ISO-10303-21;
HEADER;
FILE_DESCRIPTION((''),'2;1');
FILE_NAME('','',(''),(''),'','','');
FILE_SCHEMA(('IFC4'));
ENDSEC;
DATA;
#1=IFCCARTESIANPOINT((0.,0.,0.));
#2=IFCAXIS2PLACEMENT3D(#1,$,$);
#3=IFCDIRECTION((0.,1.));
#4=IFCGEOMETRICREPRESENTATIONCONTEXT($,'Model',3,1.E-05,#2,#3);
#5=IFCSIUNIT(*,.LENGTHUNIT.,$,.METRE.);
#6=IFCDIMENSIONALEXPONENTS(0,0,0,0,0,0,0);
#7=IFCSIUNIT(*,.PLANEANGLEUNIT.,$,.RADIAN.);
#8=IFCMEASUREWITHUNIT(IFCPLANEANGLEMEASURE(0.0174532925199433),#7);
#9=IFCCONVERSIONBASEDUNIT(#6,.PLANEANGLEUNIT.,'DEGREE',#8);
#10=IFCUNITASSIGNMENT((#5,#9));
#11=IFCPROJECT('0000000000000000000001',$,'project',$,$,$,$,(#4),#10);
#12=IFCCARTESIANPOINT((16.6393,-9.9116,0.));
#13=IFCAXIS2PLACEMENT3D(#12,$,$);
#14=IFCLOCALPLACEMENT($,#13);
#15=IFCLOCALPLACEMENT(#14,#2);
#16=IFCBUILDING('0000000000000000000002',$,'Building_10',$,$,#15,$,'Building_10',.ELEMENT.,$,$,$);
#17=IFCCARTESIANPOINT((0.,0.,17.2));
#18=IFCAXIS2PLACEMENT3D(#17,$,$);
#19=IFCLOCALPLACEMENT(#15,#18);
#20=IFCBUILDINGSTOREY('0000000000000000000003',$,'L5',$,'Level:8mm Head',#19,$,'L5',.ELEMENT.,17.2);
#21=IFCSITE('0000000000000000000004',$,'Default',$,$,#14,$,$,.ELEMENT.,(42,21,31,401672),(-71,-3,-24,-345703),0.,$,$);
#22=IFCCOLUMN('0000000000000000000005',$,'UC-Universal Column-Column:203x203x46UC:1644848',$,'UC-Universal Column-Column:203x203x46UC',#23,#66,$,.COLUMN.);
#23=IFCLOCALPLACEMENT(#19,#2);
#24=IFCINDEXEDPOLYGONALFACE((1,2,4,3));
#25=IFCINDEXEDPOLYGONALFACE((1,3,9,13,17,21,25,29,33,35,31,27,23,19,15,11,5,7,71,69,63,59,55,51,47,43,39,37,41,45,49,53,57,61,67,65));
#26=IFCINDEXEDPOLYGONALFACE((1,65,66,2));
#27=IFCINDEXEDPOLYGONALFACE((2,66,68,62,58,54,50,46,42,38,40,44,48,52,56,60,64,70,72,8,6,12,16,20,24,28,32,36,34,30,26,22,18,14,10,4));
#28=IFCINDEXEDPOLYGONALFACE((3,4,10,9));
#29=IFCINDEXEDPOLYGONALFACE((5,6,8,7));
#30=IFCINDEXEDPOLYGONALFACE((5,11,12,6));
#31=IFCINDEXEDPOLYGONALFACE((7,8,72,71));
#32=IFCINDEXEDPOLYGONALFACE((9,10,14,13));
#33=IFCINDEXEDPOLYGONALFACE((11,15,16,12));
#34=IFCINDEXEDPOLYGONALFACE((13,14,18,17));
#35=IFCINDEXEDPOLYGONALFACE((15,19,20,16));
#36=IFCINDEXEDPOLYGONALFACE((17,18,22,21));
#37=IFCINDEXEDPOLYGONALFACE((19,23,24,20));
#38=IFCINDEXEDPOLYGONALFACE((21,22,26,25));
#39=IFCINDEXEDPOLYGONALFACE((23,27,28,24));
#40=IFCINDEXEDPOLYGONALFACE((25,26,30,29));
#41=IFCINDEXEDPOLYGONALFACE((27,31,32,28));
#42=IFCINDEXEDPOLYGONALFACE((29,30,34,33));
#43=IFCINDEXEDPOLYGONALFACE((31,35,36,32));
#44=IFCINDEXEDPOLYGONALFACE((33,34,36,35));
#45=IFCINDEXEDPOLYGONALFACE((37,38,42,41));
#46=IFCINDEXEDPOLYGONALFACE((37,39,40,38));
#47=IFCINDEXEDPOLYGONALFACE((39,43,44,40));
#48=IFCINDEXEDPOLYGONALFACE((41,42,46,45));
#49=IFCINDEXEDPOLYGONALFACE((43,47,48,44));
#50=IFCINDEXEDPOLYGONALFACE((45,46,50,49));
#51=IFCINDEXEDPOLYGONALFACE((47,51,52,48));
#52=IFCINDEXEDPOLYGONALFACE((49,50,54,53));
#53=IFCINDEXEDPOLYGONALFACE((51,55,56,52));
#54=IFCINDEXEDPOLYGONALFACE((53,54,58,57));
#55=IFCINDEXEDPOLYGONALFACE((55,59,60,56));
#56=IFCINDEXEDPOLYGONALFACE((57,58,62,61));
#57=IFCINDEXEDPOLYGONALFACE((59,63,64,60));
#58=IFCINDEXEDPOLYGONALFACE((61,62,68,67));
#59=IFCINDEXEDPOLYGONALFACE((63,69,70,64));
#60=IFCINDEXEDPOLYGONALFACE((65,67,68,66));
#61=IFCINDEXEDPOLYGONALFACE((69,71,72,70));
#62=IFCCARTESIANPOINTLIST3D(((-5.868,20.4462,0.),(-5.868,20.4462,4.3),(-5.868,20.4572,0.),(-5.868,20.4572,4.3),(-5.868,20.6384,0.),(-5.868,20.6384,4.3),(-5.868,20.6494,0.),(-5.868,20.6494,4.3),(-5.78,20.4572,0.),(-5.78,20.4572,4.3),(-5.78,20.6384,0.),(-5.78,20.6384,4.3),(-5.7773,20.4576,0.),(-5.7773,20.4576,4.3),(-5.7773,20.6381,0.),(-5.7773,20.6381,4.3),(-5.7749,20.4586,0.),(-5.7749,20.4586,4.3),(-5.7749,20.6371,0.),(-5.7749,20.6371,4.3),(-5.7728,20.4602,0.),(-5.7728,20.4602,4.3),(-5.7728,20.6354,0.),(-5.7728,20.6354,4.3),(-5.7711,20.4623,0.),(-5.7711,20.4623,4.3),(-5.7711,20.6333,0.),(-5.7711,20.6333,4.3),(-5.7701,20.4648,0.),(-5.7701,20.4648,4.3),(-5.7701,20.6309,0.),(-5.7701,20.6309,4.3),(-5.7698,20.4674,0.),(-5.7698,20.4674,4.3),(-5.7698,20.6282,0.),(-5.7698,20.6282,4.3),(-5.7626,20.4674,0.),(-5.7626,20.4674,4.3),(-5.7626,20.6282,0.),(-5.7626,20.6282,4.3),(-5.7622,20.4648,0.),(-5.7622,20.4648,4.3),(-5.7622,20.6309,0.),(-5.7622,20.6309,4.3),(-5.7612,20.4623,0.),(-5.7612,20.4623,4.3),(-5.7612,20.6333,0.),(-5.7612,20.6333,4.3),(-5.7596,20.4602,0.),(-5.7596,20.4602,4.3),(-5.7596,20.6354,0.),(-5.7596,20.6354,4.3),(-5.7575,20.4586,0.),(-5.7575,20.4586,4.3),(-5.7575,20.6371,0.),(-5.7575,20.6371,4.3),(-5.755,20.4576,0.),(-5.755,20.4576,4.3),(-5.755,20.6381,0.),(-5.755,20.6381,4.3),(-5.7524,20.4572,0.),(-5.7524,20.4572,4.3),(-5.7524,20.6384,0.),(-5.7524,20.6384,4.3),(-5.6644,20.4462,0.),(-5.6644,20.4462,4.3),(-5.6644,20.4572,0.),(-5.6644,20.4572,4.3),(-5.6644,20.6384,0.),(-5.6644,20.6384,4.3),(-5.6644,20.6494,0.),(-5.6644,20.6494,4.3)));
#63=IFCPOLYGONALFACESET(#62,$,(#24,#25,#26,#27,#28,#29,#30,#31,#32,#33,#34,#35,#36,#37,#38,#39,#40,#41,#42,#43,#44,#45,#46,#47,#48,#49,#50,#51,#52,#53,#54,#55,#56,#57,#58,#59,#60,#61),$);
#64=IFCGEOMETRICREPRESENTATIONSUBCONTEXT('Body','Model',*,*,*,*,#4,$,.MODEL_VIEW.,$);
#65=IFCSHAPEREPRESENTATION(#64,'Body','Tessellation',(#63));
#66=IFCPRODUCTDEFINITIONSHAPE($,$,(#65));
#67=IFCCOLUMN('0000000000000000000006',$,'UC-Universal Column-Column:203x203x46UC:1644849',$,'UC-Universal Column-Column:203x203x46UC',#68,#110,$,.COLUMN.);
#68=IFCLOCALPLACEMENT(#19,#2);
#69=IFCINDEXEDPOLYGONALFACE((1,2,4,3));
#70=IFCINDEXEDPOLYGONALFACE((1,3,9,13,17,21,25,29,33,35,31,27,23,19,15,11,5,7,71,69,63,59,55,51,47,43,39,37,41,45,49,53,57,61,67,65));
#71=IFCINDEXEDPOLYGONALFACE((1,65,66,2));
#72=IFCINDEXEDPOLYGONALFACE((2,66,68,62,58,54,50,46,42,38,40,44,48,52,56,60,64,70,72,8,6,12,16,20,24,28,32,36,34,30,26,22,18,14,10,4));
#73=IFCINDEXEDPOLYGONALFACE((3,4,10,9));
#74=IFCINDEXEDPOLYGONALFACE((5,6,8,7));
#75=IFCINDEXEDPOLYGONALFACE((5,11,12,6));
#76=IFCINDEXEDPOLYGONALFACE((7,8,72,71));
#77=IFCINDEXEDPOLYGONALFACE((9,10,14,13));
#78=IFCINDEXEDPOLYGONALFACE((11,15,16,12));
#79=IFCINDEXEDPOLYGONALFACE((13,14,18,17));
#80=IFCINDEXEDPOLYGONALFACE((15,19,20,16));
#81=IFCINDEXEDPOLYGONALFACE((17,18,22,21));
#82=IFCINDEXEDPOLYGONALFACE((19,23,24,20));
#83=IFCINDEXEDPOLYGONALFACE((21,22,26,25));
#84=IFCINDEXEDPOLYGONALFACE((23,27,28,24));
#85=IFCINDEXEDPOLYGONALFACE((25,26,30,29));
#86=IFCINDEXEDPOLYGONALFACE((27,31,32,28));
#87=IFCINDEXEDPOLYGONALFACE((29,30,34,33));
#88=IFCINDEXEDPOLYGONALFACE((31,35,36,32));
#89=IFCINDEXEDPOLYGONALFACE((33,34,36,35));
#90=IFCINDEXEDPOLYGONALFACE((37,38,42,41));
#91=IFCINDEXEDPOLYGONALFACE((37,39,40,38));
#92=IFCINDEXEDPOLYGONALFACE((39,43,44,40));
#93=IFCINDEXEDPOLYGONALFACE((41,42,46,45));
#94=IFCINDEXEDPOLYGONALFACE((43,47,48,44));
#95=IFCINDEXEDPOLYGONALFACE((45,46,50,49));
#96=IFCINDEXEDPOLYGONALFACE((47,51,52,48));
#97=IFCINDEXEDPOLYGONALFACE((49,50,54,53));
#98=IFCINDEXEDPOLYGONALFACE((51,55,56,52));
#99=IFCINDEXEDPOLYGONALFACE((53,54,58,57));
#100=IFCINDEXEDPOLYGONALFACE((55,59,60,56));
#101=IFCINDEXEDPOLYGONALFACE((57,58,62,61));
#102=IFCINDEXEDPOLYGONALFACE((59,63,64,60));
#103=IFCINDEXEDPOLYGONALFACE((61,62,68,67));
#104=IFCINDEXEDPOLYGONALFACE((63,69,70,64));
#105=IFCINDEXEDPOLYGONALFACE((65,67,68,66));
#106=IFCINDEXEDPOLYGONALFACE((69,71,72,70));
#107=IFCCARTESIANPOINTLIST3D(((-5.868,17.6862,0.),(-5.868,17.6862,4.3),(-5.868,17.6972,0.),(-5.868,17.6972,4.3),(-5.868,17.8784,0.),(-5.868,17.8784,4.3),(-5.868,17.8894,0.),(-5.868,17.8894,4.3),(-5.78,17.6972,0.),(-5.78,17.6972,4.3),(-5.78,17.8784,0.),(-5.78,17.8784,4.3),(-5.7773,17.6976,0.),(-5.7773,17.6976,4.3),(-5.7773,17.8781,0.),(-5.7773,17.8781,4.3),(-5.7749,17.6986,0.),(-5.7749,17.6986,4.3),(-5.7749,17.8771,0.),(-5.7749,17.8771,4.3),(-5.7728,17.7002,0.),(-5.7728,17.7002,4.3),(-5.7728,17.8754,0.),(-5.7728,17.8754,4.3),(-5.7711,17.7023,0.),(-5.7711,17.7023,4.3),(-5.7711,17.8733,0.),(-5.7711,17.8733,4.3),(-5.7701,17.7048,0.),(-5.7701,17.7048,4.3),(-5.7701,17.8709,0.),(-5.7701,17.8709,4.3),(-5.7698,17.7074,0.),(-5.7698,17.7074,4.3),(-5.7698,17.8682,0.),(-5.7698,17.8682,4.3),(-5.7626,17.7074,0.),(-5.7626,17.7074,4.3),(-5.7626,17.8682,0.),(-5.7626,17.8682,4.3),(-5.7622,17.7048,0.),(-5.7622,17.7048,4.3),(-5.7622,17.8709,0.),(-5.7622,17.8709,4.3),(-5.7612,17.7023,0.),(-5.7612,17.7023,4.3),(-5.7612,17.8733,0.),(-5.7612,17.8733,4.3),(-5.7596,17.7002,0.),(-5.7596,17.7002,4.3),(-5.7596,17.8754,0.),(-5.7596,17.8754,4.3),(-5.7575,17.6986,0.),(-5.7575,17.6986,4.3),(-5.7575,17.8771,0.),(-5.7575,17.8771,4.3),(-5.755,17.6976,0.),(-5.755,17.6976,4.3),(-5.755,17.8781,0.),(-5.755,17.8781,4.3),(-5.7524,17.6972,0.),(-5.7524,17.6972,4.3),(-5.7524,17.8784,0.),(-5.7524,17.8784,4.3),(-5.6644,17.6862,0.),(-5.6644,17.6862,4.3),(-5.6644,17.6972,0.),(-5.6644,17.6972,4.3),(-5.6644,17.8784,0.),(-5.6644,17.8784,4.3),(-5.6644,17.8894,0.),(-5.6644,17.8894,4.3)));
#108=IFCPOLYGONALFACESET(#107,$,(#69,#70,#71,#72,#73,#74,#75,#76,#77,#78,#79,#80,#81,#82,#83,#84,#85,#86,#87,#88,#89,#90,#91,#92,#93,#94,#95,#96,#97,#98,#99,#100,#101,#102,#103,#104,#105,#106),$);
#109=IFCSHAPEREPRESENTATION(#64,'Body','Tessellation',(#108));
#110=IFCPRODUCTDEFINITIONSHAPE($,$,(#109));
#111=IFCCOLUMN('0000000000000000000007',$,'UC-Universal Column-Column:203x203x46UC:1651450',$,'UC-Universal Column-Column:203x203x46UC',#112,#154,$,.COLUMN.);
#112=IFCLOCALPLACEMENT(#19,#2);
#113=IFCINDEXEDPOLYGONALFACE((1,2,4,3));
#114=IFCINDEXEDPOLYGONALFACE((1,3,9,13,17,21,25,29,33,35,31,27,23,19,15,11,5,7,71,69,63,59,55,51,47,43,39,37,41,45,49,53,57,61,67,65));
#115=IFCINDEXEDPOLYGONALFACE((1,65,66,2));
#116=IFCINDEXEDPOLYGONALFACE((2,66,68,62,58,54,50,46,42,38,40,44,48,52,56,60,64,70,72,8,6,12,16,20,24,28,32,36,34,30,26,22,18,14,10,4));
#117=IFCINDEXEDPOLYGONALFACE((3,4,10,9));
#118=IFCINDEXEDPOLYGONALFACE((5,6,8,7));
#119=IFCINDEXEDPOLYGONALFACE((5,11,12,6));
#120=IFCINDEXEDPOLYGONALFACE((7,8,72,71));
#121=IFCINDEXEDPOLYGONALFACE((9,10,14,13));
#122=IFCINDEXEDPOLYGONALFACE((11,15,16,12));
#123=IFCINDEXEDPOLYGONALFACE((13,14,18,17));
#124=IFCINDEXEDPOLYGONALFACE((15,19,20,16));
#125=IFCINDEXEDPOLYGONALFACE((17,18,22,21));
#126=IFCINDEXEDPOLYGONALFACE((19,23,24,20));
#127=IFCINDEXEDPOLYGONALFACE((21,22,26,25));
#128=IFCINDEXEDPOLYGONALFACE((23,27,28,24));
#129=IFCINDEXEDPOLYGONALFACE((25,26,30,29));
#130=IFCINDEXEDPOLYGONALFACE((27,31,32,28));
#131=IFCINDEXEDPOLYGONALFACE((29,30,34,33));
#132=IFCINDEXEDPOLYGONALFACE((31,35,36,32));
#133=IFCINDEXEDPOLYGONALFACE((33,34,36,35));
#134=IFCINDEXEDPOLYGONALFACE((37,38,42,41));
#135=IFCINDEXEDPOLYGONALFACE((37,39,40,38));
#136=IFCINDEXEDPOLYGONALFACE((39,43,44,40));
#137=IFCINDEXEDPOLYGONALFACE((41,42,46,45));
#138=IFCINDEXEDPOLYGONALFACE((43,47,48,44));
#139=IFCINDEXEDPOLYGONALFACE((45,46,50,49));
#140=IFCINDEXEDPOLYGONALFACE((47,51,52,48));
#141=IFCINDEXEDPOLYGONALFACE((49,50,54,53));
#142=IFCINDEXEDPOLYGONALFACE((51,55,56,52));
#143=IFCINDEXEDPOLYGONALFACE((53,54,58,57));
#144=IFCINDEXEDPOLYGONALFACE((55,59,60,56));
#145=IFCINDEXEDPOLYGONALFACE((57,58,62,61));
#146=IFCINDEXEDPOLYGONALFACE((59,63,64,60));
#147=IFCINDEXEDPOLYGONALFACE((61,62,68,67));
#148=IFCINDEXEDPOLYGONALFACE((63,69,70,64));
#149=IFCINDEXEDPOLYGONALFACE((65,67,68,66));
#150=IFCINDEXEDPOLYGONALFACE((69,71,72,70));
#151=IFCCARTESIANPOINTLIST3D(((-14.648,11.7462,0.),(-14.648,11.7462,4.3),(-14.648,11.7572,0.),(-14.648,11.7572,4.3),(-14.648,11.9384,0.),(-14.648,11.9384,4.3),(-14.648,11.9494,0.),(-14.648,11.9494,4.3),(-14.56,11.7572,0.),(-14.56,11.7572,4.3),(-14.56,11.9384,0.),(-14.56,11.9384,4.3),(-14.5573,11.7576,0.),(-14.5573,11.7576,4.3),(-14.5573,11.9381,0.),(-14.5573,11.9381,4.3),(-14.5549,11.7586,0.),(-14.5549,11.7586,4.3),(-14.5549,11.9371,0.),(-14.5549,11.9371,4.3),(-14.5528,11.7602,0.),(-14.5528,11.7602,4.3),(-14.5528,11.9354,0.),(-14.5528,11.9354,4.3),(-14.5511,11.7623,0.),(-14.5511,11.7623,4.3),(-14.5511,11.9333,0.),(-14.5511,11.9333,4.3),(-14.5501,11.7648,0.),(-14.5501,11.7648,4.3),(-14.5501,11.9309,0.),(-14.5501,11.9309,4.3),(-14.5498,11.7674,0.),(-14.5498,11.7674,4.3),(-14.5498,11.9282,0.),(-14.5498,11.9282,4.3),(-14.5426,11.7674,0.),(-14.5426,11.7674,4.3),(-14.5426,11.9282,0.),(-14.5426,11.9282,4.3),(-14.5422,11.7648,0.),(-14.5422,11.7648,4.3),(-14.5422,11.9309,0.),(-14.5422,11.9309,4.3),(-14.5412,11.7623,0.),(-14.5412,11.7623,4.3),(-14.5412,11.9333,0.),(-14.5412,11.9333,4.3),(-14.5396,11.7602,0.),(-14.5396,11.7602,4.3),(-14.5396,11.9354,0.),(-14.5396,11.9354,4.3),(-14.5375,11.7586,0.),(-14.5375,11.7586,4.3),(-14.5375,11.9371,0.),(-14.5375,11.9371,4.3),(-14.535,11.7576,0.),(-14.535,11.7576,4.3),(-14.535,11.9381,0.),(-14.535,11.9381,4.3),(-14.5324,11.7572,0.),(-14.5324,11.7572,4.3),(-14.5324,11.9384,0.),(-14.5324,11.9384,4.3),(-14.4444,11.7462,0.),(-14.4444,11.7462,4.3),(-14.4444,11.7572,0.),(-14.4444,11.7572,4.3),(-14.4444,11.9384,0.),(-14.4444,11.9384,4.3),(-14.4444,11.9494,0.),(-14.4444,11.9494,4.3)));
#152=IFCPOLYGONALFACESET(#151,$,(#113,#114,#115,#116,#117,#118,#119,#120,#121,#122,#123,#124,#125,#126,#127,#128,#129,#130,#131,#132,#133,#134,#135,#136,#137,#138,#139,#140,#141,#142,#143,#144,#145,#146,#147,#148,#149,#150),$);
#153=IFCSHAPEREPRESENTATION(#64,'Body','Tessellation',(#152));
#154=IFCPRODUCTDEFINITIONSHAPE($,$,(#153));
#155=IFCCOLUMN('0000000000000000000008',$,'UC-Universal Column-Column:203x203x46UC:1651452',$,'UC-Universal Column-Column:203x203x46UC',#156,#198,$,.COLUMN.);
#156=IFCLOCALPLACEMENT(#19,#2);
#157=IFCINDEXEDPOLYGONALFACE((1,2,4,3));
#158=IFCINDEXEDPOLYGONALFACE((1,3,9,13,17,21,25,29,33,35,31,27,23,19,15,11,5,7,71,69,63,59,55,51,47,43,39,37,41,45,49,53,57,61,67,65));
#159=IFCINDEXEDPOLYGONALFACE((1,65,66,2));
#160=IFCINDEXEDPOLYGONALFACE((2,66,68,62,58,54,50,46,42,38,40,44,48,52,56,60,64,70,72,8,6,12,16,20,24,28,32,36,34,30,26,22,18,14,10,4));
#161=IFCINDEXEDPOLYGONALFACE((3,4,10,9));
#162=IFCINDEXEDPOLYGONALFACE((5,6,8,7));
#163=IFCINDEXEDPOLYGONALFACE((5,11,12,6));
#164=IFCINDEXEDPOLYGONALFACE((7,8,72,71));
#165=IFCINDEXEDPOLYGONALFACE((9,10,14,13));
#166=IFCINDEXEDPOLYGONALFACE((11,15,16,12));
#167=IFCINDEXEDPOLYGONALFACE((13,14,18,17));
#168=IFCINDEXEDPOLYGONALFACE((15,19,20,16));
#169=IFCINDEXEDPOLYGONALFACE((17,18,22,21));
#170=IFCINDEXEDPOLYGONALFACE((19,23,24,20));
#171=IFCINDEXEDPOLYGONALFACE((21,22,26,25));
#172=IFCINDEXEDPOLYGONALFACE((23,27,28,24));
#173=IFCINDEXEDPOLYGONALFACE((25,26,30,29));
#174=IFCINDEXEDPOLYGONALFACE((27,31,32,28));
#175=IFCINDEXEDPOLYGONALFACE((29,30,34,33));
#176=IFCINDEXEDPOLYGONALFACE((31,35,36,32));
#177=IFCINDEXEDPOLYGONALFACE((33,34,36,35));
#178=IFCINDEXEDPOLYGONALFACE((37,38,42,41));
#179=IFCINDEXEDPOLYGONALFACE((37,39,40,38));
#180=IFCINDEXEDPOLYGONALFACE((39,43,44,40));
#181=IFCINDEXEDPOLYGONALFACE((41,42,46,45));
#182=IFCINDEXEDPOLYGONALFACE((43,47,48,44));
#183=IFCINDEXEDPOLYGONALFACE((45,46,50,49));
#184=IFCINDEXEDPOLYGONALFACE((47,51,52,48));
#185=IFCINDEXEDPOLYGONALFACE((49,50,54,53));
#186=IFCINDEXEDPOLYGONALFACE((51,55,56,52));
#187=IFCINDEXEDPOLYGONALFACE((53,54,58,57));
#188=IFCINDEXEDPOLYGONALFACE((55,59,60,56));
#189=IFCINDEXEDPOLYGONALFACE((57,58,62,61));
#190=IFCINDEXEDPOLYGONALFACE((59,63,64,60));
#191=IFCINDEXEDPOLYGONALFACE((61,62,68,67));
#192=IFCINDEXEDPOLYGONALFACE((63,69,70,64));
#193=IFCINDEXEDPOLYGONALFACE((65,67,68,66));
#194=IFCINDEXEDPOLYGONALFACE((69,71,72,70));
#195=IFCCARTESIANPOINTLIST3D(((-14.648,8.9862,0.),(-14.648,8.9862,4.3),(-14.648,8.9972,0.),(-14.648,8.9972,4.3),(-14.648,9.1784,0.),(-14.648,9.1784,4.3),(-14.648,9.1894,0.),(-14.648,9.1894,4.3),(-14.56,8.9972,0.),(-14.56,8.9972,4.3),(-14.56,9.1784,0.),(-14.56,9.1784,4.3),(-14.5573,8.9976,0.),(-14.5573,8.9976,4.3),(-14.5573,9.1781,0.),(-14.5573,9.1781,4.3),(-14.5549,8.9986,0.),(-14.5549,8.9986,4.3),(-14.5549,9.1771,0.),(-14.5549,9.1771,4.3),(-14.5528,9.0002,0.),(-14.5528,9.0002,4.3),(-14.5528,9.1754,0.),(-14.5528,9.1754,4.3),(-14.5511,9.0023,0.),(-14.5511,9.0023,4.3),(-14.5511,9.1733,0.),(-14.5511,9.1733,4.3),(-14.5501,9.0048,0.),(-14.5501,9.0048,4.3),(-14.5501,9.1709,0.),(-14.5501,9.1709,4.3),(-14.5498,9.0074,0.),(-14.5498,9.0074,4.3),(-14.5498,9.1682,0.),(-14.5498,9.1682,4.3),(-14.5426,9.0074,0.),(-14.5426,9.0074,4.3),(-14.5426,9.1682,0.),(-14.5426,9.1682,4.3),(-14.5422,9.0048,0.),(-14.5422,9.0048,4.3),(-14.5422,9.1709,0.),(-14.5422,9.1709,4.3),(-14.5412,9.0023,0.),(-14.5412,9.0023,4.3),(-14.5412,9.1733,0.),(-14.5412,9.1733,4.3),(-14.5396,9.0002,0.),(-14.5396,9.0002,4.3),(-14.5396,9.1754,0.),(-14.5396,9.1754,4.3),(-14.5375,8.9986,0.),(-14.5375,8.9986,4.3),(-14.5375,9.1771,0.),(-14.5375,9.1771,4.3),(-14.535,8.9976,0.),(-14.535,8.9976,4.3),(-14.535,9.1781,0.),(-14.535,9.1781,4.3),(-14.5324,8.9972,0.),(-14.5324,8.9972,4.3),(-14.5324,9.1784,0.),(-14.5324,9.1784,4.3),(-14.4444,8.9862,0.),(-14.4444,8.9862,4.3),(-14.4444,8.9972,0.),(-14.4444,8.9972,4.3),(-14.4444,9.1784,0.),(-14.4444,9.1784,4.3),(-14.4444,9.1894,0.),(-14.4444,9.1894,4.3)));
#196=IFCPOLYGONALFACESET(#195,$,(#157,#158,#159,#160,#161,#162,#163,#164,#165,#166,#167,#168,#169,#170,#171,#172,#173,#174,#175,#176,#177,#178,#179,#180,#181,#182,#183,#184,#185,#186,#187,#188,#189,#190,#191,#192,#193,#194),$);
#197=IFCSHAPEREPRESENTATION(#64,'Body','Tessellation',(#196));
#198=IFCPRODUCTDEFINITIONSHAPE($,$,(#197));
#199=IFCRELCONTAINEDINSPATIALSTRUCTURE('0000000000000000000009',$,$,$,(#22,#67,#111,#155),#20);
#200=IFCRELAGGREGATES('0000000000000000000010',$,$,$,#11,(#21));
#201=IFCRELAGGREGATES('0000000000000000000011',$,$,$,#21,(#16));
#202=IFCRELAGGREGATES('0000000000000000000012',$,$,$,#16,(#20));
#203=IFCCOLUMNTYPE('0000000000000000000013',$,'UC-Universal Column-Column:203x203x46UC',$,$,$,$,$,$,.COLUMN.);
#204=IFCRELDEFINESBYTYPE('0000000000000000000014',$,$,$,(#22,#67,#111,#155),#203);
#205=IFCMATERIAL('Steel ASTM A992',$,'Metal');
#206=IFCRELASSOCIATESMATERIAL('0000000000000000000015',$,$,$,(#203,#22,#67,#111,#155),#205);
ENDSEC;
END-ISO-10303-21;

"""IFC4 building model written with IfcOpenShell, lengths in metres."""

from ifc_helpers import new_model, entity, si_unit, converted_unit, direction, frame, origin, place, context, subcontext, project, spatial, line, arc, indexed_curve, outline, extrude, source, transform, mapped, material, type_object, type_shapes, element, save


model = new_model("IFC4")

# Units and contexts
model_context = context("Model", 3, precision=1e-05, world=origin(), true_north=direction((0.0, 1.0)))
body_context = subcontext(model_context, "Body", "Model", "MODEL_VIEW")
ifc_project = project(units=[si_unit("LENGTHUNIT", "METRE"), converted_unit("PLANEANGLEUNIT", "DEGREE", entity("IfcPlaneAngleMeasure", 0.0174532925199433), si_unit("PLANEANGLEUNIT", "RADIAN"), dimensions=[0, 0, 0, 0, 0, 0, 0])], contexts=[model_context])

# Site, building, storey
site_placement = place(None, frame((16.6393, -9.9116, 0.0)))
site = spatial("IfcSite", under=ifc_project, at=site_placement, Name="Default", CompositionType="ELEMENT", RefLatitude=(42, 21, 31, 401672), RefLongitude=(-71, -3, -24, -345703), RefElevation=0.0)
building_placement = place(site_placement, origin())
building = spatial("IfcBuilding", under=site, at=building_placement, Name="Building_10", LongName="Building_10", CompositionType="ELEMENT")
storey_placement = place(building_placement, frame((0.0, 0.0, 17.2)))
storey = spatial("IfcBuildingStorey", under=building, at=storey_placement, Name="L5", ObjectType="Level:8mm Head", LongName="L5", CompositionType="ELEMENT", Elevation=17.2)

# Columns
ifc_material = material(Name="Steel ASTM A992", Category="Metal")
column_type = type_object("IfcColumnType", Name="UC-Universal Column-Column:203x203x46UC", PredefinedType="COLUMN", material=ifc_material)
shared_shape_1 = source(origin(), body_context, "Body", "SweptSolid", [
    extrude(outline(indexed_curve([(-0.1018, -0.1016), (0.1018, -0.1016), (0.1018, -0.0906), (0.0138, -0.0906), (0.0066, -0.0876), (0.0036, -0.0804), (0.0036, 0.0804), (0.0066, 0.0876), (0.0138, 0.0906), (0.1018, 0.0906), (0.1018, 0.1016), (-0.1018, 0.1016), (-0.1018, 0.0906), (-0.0138, 0.0906), (-0.0066, 0.0876), (-0.0036, 0.0804), (-0.0036, -0.0804), (-0.0066, -0.0876), (-0.0138, -0.0906), (-0.1018, -0.0906)], segments=[line(1, 2, 3, 4), arc(4, 5, 6), line(6, 7), arc(7, 8, 9), line(9, 10, 11, 12, 13, 14), arc(14, 15, 16), line(16, 17), arc(17, 18, 19), line(19, 20, 1)], self_intersect=False)), frame((0.0, 0.0, 17.2), z_axis=(0.0, 0.0, 1.0), x_axis=(-1.0, 0.0, 0.0)), (0.0, 0.0, 1.0), 4.3),
])
type_shapes(column_type, [shared_shape_1])
for number, where, name in (
    (1, (-5.7662, 20.5478, -17.2), "UC-Universal Column-Column:203x203x46UC:1644848"),
    (2, (-5.7662, 17.7878, -17.2), "UC-Universal Column-Column:203x203x46UC:1644849"),
    (3, (-14.5462, 11.8478, -17.2), "UC-Universal Column-Column:203x203x46UC:1651450"),
    (4, (-14.5462, 9.0878, -17.2), "UC-Universal Column-Column:203x203x46UC:1651452"),
):
    element("IfcColumn", number, at=place(storey_placement, frame(where)), inside=storey, type_object=column_type, material=ifc_material, Name=name, ObjectType="UC-Universal Column-Column:203x203x46UC", PredefinedType="COLUMN", context=body_context, shape_type="MappedRepresentation", body=[
        mapped(shared_shape_1, transform((0.0, 0.0, 0.0), scale=1.0)),
    ])

save(model, "model.ifc")
